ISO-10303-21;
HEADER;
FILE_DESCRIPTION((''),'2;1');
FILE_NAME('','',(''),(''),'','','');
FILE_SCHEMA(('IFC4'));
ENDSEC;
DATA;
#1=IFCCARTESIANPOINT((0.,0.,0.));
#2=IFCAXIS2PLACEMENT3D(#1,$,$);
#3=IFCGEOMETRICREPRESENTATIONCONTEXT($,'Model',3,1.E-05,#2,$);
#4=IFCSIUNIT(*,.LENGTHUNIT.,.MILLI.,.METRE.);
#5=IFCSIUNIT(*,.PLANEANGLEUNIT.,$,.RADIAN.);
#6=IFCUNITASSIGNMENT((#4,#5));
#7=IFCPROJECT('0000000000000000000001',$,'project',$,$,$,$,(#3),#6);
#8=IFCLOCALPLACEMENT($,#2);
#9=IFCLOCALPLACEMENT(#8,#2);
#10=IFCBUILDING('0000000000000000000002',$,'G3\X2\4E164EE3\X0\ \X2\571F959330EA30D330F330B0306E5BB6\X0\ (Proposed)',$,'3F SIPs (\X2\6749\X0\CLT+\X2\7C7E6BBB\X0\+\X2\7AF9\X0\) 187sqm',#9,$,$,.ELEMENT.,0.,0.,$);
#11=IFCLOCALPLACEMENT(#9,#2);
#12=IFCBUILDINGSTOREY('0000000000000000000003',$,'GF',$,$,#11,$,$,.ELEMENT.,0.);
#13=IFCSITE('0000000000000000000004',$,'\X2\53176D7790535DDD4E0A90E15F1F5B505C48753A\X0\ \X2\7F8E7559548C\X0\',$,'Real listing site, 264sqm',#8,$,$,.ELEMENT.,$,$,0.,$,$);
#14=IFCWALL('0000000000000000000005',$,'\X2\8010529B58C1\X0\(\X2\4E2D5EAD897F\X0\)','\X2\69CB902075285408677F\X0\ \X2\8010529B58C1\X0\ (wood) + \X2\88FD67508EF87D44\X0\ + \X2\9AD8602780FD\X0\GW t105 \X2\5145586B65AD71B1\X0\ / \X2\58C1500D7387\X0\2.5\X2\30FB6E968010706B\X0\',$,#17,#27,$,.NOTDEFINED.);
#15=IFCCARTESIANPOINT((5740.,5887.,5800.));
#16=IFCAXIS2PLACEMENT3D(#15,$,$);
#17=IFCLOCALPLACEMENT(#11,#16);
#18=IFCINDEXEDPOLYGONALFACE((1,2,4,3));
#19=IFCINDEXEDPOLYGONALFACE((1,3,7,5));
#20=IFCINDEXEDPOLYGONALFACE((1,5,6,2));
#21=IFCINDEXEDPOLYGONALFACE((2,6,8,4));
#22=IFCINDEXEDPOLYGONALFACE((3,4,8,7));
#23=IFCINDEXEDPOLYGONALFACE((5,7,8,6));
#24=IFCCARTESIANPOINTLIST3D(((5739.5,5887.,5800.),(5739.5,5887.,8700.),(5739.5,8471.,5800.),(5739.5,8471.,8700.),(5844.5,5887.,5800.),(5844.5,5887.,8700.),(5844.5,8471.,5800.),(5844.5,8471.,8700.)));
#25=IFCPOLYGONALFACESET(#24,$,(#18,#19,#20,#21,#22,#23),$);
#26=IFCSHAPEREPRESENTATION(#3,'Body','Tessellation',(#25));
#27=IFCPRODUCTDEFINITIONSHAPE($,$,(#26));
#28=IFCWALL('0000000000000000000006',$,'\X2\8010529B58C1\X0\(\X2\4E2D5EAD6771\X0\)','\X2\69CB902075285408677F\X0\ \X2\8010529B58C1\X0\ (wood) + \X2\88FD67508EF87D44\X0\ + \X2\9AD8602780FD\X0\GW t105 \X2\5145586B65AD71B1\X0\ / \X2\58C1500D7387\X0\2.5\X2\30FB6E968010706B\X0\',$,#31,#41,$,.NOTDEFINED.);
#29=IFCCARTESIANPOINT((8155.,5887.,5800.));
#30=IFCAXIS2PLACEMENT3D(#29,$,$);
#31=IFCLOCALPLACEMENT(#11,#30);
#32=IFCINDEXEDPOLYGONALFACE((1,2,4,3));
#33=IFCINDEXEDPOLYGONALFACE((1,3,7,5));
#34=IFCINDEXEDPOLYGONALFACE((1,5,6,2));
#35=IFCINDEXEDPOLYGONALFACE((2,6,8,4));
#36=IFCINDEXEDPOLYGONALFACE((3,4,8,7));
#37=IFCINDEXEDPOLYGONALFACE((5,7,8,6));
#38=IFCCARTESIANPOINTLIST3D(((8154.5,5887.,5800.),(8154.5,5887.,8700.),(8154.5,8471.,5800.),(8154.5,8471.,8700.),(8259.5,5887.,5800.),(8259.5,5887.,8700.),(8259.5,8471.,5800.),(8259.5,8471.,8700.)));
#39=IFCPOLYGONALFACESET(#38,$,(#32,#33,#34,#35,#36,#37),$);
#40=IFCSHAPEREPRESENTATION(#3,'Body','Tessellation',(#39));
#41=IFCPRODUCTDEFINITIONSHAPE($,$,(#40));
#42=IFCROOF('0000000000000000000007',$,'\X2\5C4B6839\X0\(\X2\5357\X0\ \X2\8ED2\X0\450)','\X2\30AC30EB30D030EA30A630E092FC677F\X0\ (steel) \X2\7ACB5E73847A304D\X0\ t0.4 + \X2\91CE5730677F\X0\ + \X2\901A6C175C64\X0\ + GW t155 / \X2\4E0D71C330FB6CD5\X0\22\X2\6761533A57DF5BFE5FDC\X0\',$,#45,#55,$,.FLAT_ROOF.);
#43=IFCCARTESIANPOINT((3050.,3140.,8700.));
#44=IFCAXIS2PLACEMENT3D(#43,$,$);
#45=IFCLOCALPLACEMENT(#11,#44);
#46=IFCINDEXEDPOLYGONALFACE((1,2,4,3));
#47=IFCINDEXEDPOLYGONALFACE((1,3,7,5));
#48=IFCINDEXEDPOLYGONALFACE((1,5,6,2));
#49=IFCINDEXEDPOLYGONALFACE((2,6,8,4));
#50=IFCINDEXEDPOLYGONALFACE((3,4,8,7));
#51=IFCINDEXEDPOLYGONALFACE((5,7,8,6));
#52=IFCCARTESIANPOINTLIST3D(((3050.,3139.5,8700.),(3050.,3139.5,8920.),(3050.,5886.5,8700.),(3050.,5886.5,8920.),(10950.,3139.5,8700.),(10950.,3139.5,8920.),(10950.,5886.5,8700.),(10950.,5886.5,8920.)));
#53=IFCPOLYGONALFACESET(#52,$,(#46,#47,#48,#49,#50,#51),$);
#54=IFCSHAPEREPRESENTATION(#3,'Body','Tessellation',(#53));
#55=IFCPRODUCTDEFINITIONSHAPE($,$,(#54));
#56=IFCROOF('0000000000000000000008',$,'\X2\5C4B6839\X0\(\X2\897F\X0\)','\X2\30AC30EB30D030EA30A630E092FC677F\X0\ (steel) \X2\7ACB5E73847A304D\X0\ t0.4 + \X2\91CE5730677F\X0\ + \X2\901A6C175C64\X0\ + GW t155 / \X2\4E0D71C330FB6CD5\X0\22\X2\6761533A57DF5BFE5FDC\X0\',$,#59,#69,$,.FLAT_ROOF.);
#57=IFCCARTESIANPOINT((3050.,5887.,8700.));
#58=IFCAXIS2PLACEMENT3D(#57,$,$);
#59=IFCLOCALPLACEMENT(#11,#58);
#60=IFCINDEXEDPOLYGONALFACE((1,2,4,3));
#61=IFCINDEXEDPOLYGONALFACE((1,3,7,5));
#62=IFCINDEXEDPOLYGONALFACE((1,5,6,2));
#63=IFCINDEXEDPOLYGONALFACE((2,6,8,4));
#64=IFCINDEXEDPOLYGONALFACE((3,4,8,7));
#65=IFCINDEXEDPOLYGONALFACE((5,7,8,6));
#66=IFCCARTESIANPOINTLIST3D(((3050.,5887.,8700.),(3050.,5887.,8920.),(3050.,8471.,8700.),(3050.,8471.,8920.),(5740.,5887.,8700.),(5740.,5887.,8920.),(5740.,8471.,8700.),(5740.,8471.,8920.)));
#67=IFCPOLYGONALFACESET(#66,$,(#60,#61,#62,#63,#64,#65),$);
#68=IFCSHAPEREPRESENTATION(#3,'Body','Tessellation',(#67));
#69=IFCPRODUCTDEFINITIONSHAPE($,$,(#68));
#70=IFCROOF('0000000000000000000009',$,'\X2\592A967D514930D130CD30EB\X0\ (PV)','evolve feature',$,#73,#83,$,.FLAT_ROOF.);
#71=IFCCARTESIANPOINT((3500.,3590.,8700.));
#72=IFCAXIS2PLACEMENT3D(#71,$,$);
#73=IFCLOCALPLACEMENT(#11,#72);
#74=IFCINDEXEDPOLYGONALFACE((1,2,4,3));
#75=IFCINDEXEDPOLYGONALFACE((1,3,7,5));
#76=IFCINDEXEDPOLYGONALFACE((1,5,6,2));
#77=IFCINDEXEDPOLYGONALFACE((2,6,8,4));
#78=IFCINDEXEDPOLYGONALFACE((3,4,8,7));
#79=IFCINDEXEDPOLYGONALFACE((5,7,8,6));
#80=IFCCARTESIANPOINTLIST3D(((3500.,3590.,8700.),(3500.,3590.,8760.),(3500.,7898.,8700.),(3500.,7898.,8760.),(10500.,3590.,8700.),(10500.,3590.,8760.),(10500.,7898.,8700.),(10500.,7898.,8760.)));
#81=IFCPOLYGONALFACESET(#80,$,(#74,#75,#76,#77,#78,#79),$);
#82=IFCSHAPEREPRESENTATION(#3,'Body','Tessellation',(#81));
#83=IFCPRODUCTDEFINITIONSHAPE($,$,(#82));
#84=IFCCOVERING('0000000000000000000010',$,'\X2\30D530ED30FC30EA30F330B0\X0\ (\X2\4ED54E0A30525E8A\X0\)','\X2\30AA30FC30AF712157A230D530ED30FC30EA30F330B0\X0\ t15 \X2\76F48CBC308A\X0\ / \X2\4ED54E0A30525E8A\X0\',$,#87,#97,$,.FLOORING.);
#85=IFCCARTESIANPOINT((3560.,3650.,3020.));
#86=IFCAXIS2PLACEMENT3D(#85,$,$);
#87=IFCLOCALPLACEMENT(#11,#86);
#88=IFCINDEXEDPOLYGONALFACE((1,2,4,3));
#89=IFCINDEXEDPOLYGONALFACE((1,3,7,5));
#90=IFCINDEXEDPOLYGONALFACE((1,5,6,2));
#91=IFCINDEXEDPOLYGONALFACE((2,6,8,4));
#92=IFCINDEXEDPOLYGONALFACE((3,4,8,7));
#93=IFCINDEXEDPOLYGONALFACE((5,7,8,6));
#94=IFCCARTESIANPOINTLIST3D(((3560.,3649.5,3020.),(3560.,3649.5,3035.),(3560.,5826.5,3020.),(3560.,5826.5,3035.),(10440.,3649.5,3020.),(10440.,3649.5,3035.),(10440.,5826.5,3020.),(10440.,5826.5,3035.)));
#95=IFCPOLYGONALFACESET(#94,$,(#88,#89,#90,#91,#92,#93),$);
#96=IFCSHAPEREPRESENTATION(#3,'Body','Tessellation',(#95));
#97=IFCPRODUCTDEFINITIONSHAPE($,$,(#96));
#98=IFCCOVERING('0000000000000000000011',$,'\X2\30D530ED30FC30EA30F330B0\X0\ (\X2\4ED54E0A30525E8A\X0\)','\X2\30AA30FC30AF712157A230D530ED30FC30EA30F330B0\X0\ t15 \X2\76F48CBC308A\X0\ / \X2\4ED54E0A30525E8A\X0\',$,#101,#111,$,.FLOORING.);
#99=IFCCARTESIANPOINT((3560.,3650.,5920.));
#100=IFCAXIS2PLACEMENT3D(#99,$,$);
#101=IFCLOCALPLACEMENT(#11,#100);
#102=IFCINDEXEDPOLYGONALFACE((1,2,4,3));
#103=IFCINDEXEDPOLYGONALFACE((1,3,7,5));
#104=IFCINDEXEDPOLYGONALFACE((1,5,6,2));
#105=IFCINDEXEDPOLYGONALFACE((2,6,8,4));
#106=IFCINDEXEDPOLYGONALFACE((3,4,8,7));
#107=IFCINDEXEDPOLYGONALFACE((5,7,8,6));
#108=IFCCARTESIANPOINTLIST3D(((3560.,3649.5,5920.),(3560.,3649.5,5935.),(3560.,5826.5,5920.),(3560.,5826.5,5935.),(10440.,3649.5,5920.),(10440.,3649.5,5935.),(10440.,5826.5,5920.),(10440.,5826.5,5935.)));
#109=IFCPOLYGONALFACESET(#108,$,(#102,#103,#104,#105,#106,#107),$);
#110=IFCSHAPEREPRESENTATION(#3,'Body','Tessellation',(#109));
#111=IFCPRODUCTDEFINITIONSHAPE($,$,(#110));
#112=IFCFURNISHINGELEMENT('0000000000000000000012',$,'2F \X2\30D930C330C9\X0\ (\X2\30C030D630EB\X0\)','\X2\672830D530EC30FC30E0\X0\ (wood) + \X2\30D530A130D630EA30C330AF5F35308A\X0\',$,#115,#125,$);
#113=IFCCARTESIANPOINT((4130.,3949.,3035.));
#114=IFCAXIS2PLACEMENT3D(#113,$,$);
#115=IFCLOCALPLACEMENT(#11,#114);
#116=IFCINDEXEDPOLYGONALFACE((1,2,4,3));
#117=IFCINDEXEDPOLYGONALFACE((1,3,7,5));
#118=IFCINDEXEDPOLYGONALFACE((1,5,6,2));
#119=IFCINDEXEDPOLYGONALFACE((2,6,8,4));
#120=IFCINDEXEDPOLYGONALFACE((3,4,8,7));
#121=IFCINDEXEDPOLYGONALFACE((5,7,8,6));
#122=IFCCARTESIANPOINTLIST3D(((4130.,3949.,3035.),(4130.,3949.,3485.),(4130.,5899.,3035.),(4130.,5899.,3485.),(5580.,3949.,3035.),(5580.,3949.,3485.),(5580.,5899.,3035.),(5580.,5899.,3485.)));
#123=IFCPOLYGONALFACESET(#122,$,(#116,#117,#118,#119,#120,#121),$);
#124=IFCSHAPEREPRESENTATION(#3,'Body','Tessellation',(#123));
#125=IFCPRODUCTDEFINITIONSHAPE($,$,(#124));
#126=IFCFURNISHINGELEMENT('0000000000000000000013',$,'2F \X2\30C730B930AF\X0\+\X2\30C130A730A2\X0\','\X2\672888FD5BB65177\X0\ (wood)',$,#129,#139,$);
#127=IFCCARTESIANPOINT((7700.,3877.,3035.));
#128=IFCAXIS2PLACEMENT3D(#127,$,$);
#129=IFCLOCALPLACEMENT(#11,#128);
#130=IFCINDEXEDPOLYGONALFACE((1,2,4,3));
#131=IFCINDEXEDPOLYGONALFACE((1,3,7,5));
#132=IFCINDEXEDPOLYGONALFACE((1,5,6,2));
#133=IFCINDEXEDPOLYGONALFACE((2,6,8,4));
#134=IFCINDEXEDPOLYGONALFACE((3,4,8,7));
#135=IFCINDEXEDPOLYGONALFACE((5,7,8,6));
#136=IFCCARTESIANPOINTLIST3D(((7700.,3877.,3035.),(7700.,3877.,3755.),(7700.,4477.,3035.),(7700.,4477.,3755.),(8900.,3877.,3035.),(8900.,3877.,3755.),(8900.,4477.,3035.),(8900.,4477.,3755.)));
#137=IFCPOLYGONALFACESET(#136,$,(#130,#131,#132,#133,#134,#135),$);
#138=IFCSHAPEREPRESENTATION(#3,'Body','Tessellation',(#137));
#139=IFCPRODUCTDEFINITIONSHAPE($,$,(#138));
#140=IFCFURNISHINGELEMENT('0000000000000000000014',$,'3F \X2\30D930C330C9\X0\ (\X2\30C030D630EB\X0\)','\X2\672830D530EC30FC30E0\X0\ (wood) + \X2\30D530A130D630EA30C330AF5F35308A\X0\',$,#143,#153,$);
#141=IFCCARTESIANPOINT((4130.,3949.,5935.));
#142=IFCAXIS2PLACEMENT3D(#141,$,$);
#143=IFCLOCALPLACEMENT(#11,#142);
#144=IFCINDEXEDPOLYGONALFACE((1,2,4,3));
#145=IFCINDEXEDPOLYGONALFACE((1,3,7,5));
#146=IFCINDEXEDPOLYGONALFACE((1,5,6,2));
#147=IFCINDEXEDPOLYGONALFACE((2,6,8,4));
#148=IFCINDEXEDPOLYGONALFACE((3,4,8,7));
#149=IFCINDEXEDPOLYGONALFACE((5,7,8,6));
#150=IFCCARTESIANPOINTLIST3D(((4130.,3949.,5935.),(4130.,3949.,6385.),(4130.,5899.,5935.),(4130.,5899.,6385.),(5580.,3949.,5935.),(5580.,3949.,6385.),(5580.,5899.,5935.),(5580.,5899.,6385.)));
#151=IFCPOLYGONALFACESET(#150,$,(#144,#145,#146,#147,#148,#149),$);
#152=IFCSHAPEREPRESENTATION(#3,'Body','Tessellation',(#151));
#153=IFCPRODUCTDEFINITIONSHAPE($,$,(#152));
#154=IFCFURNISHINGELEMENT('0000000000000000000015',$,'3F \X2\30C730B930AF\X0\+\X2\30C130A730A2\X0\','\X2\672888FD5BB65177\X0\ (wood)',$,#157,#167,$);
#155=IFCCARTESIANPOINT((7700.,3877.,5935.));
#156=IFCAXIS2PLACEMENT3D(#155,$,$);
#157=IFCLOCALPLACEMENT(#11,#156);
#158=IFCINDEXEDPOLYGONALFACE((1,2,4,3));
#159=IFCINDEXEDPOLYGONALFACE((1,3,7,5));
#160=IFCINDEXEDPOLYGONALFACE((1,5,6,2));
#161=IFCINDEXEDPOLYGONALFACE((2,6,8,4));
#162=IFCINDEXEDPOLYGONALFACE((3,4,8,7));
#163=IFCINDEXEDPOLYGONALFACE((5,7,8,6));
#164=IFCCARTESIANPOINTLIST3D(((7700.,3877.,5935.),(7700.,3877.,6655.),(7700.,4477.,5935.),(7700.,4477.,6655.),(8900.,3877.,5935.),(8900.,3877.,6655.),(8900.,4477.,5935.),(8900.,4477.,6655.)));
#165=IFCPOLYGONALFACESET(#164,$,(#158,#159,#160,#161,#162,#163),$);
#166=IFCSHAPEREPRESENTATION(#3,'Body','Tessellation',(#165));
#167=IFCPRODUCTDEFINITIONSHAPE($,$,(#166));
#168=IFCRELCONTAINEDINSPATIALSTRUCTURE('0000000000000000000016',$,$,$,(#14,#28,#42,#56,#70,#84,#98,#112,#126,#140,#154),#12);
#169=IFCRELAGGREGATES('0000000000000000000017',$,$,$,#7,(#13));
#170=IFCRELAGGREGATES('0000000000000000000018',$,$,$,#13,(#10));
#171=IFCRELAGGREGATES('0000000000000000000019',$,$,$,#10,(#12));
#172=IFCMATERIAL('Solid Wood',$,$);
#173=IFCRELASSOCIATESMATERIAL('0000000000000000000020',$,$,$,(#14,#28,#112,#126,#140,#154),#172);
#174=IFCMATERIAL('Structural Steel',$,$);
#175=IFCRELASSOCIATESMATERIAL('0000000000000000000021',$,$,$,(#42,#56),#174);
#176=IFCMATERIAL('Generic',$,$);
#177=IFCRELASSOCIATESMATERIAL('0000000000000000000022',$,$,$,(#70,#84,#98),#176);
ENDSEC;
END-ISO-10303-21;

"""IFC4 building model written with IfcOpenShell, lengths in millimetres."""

from ifc_helpers import new_model, si_unit, frame, frame_2d, origin, place, context, project, spatial, rectangle, extrude, material, element, save


model = new_model("IFC4")

# Units and contexts
model_context = context("Model", 3, precision=1e-05, world=origin())
ifc_project = project(units=[si_unit("LENGTHUNIT", "METRE", prefix="MILLI"), si_unit("PLANEANGLEUNIT", "RADIAN")], contexts=[model_context])

# Site, building, storey
site_placement = place(None, origin())
site = spatial("IfcSite", under=ifc_project, at=site_placement, Name="北海道川上郡弟子屈町 美留和", ObjectType="Real listing site, 264sqm", CompositionType="ELEMENT", RefElevation=0.0)
building_placement = place(site_placement, origin())
building = spatial("IfcBuilding", under=site, at=building_placement, Name="G3世代 土間リビングの家 (Proposed)", ObjectType="3F SIPs (杉CLT+籾殻+竹) 187sqm", CompositionType="ELEMENT", ElevationOfRefHeight=0.0, ElevationOfTerrain=0.0)
storey_placement = place(building_placement, origin())
storey = spatial("IfcBuildingStorey", under=building, at=storey_placement, Name="GF", CompositionType="ELEMENT", Elevation=0.0)

# Shared definitions
ifc_material_1 = material(Name="Solid Wood")

# Walls
wall_1_placement = place(storey_placement, frame((5740.0, 5887.0, 5800.0)))
element("IfcWall", 1, at=wall_1_placement, inside=storey, material=ifc_material_1, Name="耐力壁(中庭西)", Description="構造用合板 耐力壁 (wood) + 製材軸組 + 高性能GW t105 充填断熱 / 壁倍率2.5・準耐火", PredefinedType="NOTDEFINED", context=model_context, shape_type="SweptSolid", body=[
    extrude(rectangle(XDim=105.0, YDim=2584.0, at=frame_2d((52.0, 1292.0))), frame((5740.0, 5887.0, 5800.0)), (0.0, 0.0, 1.0), 2900.0),
])
wall_2_placement = place(storey_placement, frame((8155.0, 5887.0, 5800.0)))
element("IfcWall", 2, at=wall_2_placement, inside=storey, material=ifc_material_1, Name="耐力壁(中庭東)", Description="構造用合板 耐力壁 (wood) + 製材軸組 + 高性能GW t105 充填断熱 / 壁倍率2.5・準耐火", PredefinedType="NOTDEFINED", context=model_context, shape_type="SweptSolid", body=[
    extrude(rectangle(XDim=105.0, YDim=2584.0, at=frame_2d((52.0, 1292.0))), frame((8155.0, 5887.0, 5800.0)), (0.0, 0.0, 1.0), 2900.0),
])

# Roofs
ifc_material_2 = material(Name="Structural Steel")
roof_1_placement = place(storey_placement, frame((3050.0, 3140.0, 8700.0)))
element("IfcRoof", 3, at=roof_1_placement, inside=storey, material=ifc_material_2, Name="屋根(南 軒450)", Description="ガルバリウム鋼板 (steel) 立平葺き t0.4 + 野地板 + 通気層 + GW t155 / 不燃・法22条区域対応", PredefinedType="FLAT_ROOF", context=model_context, shape_type="SweptSolid", body=[
    extrude(rectangle(XDim=7900.0, YDim=2747.0, at=frame_2d((3950.0, 1373.0))), frame((3050.0, 3140.0, 8700.0)), (0.0, 0.0, 1.0), 220.0),
])
roof_2_placement = place(storey_placement, frame((3050.0, 5887.0, 8700.0)))
element("IfcRoof", 4, at=roof_2_placement, inside=storey, material=ifc_material_2, Name="屋根(西)", Description="ガルバリウム鋼板 (steel) 立平葺き t0.4 + 野地板 + 通気層 + GW t155 / 不燃・法22条区域対応", PredefinedType="FLAT_ROOF", context=model_context, shape_type="SweptSolid", body=[
    extrude(rectangle(XDim=2690.0, YDim=2584.0, at=frame_2d((1345.0, 1292.0))), frame((3050.0, 5887.0, 8700.0)), (0.0, 0.0, 1.0), 220.0),
])
ifc_material_3 = material(Name="Generic")
roof_3_placement = place(storey_placement, frame((3500.0, 3590.0, 8700.0)))
element("IfcRoof", 5, at=roof_3_placement, inside=storey, material=ifc_material_3, Name="太陽光パネル (PV)", Description="evolve feature", PredefinedType="FLAT_ROOF", context=model_context, shape_type="SweptSolid", body=[
    extrude(rectangle(XDim=7000.0, YDim=4308.0, at=frame_2d((3500.0, 2154.0))), frame((3500.0, 3590.0, 8700.0)), (0.0, 0.0, 1.0), 60.0),
])

# Coverings
covering_1_placement = place(storey_placement, frame((3560.0, 3650.0, 3020.0)))
element("IfcCovering", 6, at=covering_1_placement, inside=storey, material=ifc_material_3, Name="フローリング (仕上げ床)", Description="オーク無垢フローリング t15 直貼り / 仕上げ床", PredefinedType="FLOORING", context=model_context, shape_type="SweptSolid", body=[
    extrude(rectangle(XDim=6880.0, YDim=2177.0, at=frame_2d((3440.0, 1088.0))), frame((3560.0, 3650.0, 3020.0)), (0.0, 0.0, 1.0), 15.0),
])
covering_2_placement = place(storey_placement, frame((3560.0, 3650.0, 5920.0)))
element("IfcCovering", 7, at=covering_2_placement, inside=storey, material=ifc_material_3, Name="フローリング (仕上げ床)", Description="オーク無垢フローリング t15 直貼り / 仕上げ床", PredefinedType="FLOORING", context=model_context, shape_type="SweptSolid", body=[
    extrude(rectangle(XDim=6880.0, YDim=2177.0, at=frame_2d((3440.0, 1088.0))), frame((3560.0, 3650.0, 5920.0)), (0.0, 0.0, 1.0), 15.0),
])

# Furnishing elements
furnishing_1_placement = place(storey_placement, frame((4130.0, 3949.0, 3035.0)))
element("IfcFurnishingElement", 8, at=furnishing_1_placement, inside=storey, material=ifc_material_1, Name="2F ベッド (ダブル)", Description="木フレーム (wood) + ファブリック張り", context=model_context, shape_type="SweptSolid", body=[
    extrude(rectangle(XDim=1450.0, YDim=1950.0, at=frame_2d((725.0, 975.0))), frame((4130.0, 3949.0, 3035.0)), (0.0, 0.0, 1.0), 450.0),
])
furnishing_2_placement = place(storey_placement, frame((7700.0, 3877.0, 3035.0)))
element("IfcFurnishingElement", 9, at=furnishing_2_placement, inside=storey, material=ifc_material_1, Name="2F デスク+チェア", Description="木製家具 (wood)", context=model_context, shape_type="SweptSolid", body=[
    extrude(rectangle(XDim=1200.0, YDim=600.0, at=frame_2d((600.0, 300.0))), frame((7700.0, 3877.0, 3035.0)), (0.0, 0.0, 1.0), 720.0),
])
furnishing_3_placement = place(storey_placement, frame((4130.0, 3949.0, 5935.0)))
element("IfcFurnishingElement", 10, at=furnishing_3_placement, inside=storey, material=ifc_material_1, Name="3F ベッド (ダブル)", Description="木フレーム (wood) + ファブリック張り", context=model_context, shape_type="SweptSolid", body=[
    extrude(rectangle(XDim=1450.0, YDim=1950.0, at=frame_2d((725.0, 975.0))), frame((4130.0, 3949.0, 5935.0)), (0.0, 0.0, 1.0), 450.0),
])
furnishing_4_placement = place(storey_placement, frame((7700.0, 3877.0, 5935.0)))
element("IfcFurnishingElement", 11, at=furnishing_4_placement, inside=storey, material=ifc_material_1, Name="3F デスク+チェア", Description="木製家具 (wood)", context=model_context, shape_type="SweptSolid", body=[
    extrude(rectangle(XDim=1200.0, YDim=600.0, at=frame_2d((600.0, 300.0))), frame((7700.0, 3877.0, 5935.0)), (0.0, 0.0, 1.0), 720.0),
])

save(model, "model.ifc")
